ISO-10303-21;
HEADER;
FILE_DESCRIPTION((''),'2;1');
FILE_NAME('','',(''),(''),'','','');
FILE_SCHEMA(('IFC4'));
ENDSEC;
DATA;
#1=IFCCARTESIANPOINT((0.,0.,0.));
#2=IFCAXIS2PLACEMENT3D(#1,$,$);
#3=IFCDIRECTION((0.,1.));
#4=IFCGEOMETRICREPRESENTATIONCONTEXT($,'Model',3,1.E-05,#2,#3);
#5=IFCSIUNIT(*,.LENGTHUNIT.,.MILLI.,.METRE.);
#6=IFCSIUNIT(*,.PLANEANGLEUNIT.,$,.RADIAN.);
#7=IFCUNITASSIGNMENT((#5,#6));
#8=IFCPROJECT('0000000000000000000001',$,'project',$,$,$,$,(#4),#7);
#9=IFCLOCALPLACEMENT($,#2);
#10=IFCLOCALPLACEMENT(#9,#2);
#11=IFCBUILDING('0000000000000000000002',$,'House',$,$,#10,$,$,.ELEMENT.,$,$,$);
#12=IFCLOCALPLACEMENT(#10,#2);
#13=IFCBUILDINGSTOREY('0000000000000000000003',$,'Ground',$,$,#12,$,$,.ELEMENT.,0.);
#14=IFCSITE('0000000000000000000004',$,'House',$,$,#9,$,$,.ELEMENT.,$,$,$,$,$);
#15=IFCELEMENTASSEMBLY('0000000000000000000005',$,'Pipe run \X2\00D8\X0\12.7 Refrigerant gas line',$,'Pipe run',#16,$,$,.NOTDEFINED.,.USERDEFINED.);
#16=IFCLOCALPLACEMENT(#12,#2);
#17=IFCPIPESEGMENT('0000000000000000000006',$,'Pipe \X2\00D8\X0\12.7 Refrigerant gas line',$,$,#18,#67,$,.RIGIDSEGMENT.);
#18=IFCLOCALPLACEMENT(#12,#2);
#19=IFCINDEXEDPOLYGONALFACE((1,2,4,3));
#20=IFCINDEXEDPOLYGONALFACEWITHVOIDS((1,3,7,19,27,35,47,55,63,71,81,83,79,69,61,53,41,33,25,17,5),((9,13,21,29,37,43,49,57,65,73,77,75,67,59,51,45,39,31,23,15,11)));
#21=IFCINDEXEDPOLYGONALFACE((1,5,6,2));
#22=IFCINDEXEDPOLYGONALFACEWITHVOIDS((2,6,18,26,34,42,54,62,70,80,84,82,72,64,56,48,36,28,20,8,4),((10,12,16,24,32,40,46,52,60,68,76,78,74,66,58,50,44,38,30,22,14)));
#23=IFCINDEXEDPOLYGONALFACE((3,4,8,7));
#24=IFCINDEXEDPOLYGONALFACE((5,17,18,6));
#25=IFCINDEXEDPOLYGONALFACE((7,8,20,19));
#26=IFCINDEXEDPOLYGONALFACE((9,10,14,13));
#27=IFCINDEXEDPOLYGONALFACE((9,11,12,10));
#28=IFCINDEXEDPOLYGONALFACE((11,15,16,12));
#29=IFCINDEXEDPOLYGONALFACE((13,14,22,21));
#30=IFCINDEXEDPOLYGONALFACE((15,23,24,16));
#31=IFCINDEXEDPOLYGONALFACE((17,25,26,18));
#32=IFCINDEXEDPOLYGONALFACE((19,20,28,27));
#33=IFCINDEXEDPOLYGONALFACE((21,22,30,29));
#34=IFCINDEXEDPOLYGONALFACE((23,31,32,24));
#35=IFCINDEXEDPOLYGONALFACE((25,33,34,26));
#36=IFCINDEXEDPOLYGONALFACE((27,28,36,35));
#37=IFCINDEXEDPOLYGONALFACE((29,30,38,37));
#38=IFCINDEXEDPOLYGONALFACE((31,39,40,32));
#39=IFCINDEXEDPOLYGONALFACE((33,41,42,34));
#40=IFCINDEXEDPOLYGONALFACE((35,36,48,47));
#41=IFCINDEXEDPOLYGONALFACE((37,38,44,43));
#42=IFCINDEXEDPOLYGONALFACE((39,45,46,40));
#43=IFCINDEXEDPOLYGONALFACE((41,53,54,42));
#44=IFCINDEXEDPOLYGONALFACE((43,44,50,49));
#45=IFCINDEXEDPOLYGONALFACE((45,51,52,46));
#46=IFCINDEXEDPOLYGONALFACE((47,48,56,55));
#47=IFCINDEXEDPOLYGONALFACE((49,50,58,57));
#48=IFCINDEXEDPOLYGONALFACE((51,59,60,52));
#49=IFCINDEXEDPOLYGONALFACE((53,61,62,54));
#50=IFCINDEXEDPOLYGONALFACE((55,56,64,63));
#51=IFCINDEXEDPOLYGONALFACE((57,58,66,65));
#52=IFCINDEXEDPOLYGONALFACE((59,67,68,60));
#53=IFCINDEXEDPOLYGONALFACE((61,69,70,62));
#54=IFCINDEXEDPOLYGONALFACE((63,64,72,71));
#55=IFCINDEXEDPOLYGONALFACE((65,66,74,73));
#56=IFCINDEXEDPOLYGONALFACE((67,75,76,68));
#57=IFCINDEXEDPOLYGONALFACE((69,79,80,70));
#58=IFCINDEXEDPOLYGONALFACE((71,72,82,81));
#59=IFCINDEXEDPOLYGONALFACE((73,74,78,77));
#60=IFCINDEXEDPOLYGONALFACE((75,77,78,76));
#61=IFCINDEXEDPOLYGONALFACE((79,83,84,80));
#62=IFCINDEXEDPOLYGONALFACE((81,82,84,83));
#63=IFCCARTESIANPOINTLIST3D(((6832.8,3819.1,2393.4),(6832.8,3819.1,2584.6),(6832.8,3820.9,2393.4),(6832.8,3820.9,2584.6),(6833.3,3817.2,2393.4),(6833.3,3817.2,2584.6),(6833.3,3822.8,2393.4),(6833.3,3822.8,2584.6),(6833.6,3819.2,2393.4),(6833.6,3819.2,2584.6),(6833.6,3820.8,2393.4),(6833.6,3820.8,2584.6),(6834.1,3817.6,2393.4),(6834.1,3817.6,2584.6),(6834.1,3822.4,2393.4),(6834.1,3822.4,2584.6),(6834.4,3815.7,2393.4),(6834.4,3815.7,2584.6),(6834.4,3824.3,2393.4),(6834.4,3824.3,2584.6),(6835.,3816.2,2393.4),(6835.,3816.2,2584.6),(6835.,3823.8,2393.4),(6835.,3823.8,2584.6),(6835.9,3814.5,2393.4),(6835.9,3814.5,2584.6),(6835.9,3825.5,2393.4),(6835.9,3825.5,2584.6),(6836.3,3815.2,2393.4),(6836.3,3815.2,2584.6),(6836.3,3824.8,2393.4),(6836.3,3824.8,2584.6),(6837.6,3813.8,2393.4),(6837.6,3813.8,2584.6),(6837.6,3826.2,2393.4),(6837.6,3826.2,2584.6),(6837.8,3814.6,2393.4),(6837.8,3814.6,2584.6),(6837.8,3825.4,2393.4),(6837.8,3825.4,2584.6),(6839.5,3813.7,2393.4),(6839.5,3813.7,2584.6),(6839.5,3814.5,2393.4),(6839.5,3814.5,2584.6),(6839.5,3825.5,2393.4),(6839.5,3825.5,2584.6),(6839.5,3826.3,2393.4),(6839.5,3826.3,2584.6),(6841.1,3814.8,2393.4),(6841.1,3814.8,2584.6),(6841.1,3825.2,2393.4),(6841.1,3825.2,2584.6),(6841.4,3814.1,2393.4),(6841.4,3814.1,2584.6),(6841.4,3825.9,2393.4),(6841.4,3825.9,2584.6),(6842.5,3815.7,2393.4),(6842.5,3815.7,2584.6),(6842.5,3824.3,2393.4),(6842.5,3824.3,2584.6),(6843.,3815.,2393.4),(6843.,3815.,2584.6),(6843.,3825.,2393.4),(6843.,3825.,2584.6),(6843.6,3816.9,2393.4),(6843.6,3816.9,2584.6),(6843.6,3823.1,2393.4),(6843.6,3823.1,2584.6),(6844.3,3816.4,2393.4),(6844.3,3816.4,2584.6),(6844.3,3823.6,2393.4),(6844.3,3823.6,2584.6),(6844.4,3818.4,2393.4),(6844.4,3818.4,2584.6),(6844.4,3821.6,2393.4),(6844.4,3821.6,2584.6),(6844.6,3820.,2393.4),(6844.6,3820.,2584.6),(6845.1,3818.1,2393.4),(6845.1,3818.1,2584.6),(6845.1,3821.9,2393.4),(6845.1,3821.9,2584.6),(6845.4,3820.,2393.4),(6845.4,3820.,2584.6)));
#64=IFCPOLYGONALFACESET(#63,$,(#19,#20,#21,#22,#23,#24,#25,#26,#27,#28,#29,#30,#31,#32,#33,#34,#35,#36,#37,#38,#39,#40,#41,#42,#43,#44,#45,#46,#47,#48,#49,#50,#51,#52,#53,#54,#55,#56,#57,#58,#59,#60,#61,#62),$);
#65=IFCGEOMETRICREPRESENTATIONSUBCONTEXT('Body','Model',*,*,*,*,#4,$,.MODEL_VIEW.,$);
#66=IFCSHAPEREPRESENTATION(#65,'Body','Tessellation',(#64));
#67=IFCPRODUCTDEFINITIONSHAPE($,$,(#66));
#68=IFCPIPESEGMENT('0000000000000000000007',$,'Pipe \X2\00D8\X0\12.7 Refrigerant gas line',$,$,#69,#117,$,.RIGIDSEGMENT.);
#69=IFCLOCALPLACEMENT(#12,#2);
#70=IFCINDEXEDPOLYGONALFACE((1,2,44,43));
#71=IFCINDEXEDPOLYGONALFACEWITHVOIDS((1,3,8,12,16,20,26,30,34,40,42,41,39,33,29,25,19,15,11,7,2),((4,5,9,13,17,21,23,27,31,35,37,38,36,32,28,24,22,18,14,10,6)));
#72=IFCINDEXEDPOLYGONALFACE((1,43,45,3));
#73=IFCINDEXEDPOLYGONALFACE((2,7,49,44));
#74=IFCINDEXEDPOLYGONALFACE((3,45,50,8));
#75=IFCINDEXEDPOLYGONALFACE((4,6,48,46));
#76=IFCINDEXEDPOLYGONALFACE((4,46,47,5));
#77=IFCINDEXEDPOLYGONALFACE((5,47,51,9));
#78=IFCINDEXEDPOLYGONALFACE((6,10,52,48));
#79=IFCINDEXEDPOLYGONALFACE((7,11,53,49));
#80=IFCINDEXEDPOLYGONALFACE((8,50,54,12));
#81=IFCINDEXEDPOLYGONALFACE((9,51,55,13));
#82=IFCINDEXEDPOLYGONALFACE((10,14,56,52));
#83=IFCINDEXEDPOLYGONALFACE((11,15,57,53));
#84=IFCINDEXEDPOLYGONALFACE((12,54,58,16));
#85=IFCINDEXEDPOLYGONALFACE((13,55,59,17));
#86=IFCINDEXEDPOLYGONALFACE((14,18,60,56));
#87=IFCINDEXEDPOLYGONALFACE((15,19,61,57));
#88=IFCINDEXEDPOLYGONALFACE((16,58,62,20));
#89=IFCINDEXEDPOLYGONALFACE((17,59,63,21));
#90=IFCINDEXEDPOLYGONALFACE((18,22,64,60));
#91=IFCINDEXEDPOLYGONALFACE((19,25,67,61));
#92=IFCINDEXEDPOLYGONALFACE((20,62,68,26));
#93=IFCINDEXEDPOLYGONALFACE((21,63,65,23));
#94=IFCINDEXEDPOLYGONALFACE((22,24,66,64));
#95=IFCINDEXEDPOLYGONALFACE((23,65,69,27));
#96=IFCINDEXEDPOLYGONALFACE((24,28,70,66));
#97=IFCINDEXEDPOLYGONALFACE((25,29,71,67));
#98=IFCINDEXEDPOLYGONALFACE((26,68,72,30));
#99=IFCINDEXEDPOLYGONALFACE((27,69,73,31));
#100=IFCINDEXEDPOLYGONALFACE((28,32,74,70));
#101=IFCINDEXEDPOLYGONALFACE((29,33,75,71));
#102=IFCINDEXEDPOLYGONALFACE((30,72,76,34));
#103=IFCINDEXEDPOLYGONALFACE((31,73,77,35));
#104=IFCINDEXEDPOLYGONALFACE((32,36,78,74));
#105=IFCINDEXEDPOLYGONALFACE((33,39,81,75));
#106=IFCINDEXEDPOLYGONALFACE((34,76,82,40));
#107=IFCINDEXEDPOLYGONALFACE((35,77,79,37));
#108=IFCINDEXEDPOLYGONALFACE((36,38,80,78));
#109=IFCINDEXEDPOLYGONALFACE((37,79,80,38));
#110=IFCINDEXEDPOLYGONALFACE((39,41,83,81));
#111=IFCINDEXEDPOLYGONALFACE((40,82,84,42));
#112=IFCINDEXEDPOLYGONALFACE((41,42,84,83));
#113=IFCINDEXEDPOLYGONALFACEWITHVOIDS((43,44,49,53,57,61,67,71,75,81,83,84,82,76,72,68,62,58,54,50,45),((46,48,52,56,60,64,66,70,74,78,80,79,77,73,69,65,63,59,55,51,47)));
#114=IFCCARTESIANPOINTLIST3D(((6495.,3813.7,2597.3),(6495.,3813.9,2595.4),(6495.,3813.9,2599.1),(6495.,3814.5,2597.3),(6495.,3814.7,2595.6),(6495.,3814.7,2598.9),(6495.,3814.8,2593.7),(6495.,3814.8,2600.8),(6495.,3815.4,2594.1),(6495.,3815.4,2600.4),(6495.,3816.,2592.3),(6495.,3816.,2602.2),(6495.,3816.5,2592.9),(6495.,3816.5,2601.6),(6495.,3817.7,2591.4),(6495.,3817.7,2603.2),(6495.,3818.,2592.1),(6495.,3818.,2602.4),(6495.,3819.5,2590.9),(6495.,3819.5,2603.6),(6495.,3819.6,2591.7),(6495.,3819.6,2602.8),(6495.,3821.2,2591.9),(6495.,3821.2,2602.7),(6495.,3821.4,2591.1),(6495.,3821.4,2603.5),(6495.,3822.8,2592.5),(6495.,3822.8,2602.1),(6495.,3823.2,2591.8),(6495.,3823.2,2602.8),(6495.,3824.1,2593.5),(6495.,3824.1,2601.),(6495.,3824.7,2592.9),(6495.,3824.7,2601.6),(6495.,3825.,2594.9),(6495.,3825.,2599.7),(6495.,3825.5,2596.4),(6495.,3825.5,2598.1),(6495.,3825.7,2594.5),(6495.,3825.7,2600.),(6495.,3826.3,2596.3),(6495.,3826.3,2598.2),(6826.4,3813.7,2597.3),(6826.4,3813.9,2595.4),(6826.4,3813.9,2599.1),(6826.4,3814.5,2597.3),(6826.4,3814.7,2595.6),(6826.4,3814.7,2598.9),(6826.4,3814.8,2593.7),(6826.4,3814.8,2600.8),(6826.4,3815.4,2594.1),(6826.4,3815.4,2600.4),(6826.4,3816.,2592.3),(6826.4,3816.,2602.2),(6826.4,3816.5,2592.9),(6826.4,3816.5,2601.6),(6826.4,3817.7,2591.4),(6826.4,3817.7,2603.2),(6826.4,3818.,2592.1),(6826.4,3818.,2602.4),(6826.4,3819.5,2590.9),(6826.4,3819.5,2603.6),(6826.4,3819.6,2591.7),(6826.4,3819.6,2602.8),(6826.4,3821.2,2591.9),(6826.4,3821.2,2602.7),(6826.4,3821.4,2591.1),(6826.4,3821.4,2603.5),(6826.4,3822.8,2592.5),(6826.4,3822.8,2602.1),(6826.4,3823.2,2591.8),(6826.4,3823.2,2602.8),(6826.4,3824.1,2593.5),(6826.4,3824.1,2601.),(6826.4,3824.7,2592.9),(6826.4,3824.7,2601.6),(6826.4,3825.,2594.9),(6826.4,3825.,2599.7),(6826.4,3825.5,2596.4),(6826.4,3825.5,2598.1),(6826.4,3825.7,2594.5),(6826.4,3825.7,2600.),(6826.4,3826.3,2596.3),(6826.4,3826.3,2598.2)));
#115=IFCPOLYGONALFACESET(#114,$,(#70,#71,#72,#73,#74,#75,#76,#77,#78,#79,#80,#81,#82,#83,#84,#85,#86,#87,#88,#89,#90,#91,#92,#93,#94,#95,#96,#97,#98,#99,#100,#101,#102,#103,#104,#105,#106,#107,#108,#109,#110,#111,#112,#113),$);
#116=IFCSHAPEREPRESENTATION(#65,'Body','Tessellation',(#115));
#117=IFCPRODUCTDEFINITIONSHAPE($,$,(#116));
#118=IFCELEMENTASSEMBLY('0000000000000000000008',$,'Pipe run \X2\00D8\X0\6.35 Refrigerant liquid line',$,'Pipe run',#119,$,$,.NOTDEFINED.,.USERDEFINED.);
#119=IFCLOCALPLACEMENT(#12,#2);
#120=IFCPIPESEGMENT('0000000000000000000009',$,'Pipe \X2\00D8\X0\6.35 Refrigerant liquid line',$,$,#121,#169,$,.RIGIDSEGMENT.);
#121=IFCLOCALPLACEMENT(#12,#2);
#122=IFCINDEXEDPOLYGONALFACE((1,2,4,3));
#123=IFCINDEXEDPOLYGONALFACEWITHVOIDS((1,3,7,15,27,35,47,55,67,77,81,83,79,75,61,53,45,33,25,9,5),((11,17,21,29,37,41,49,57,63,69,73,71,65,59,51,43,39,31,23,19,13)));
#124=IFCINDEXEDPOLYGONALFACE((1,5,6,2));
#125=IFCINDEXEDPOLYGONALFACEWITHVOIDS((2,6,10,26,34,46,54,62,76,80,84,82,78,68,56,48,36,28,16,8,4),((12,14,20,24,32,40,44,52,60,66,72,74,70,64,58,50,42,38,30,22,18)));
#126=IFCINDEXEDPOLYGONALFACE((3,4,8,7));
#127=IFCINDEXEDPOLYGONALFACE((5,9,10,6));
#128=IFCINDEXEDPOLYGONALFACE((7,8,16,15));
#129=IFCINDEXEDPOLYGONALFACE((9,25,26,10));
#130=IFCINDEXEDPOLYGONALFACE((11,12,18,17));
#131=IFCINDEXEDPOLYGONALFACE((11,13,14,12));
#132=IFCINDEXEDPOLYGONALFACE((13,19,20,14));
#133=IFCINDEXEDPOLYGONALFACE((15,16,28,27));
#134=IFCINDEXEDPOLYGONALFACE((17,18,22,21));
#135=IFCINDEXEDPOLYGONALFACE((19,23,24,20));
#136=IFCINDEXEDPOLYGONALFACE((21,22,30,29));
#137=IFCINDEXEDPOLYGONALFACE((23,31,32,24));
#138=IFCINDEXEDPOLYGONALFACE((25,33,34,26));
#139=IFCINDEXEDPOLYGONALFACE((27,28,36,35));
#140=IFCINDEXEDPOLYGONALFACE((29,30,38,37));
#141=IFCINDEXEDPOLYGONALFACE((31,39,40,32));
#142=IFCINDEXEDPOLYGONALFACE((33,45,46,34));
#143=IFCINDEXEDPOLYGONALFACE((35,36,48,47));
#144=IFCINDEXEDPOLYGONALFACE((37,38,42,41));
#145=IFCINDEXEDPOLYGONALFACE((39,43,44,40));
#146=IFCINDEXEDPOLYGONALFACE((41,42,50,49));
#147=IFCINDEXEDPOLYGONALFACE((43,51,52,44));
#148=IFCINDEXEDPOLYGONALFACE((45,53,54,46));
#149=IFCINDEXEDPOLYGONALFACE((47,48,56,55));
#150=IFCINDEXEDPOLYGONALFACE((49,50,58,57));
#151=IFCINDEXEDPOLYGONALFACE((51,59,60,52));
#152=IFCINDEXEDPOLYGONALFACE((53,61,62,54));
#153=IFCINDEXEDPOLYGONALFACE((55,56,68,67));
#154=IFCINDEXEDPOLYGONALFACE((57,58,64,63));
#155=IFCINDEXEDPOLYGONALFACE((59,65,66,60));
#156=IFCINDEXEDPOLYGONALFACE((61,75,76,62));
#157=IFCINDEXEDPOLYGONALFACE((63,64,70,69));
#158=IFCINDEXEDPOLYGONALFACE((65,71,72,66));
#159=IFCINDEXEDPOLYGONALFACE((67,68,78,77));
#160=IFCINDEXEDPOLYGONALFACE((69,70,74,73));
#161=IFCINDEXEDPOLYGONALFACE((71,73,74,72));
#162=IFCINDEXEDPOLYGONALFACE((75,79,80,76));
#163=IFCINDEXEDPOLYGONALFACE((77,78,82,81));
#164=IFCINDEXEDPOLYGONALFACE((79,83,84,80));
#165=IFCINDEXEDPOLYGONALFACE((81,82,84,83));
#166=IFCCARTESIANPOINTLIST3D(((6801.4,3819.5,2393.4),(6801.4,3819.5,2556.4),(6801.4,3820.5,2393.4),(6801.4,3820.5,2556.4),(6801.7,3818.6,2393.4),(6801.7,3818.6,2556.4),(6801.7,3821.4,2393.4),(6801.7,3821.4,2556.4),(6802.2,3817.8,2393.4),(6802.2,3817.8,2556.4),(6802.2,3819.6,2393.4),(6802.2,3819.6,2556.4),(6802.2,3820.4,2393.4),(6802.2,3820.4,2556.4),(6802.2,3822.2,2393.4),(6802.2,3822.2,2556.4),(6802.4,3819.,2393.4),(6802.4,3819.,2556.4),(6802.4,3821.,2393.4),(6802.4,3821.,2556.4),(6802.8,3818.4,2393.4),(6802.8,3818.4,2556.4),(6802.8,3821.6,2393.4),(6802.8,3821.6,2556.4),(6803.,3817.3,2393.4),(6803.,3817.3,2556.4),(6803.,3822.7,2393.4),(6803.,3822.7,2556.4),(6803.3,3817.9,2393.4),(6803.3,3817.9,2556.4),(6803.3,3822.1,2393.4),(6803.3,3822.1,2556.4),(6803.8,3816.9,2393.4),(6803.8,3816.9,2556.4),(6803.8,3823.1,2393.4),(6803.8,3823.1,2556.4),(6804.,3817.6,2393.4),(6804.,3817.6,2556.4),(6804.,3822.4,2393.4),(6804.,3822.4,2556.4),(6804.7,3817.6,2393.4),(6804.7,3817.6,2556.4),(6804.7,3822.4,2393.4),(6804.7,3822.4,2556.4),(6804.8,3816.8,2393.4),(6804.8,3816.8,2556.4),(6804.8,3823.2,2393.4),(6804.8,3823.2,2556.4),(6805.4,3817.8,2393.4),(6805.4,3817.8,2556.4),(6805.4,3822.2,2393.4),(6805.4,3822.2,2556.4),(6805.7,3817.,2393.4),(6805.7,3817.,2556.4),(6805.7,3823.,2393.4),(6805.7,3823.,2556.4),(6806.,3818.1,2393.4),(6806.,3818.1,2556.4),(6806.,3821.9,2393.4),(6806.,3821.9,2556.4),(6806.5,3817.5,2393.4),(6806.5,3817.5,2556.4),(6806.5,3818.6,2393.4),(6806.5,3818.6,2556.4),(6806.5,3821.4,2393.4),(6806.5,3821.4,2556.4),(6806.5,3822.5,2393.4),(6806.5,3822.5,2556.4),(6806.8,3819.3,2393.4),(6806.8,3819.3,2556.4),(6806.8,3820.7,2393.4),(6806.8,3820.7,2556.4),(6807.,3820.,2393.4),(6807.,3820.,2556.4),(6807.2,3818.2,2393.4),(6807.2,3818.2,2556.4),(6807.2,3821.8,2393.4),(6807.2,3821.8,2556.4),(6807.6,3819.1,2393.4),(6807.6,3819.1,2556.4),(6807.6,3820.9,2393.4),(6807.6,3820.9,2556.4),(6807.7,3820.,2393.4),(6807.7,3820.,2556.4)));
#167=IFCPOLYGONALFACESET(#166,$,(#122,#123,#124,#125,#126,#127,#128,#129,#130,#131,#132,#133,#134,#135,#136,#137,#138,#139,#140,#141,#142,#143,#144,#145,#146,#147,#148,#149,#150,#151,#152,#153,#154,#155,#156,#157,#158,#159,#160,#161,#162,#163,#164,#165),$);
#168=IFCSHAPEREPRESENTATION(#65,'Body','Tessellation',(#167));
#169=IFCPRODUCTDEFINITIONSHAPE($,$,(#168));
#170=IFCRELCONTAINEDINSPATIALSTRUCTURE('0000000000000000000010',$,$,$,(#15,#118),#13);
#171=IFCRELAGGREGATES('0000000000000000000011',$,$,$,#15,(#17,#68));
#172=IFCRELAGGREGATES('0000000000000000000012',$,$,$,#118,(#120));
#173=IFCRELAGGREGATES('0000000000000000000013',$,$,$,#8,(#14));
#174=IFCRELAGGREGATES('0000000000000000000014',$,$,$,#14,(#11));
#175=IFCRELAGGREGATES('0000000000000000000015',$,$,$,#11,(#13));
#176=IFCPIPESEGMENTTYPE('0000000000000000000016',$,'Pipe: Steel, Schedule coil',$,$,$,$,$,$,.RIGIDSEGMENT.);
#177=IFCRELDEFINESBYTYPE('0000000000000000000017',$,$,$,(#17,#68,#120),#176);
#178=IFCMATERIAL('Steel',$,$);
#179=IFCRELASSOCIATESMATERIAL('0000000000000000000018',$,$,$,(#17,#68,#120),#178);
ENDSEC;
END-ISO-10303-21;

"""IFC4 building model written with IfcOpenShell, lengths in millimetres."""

from ifc_helpers import new_model, si_unit, direction, frame, origin, origin_with_axes, origin_2d, place, context, subcontext, project, spatial, hollow_circle, extrude, material, type_object, element, aggregate, save


model = new_model("IFC4")

# Units and contexts
model_context = context("Model", 3, precision=1e-05, world=origin(), true_north=direction((0.0, 1.0)))
body_context = subcontext(model_context, "Body", "Model", "MODEL_VIEW")
ifc_project = project(units=[si_unit("LENGTHUNIT", "METRE", prefix="MILLI"), si_unit("PLANEANGLEUNIT", "RADIAN")], contexts=[model_context])

# Site, building, storey
site_placement = place(None, origin())
site = spatial("IfcSite", under=ifc_project, at=site_placement, Name="House", CompositionType="ELEMENT")
building_placement = place(site_placement, origin())
building = spatial("IfcBuilding", under=site, at=building_placement, Name="House", CompositionType="ELEMENT")
storey_placement = place(building_placement, origin())
storey = spatial("IfcBuildingStorey", under=building, at=storey_placement, Name="Ground", CompositionType="ELEMENT", Elevation=0.0)

# Element assemblies, pipe segments
assembly_1_placement = place(storey_placement, origin_with_axes())
assembly_1 = element("IfcElementAssembly", 1, at=assembly_1_placement, inside=storey, Name="Pipe run Ø12.7 Refrigerant gas line", ObjectType="Pipe run", AssemblyPlace="NOTDEFINED", PredefinedType="USERDEFINED")
ifc_material = material(Name="Steel")
pipe_segment_type = type_object("IfcPipeSegmentType", Name="Pipe: Steel, Schedule coil", PredefinedType="RIGIDSEGMENT")
pipe_segment_1_placement = place(storey_placement, origin_with_axes())
pipe_segment_1 = element("IfcPipeSegment", 2, at=pipe_segment_1_placement, type_object=pipe_segment_type, material=ifc_material, Name="Pipe Ø12.7 Refrigerant gas line", PredefinedType="RIGIDSEGMENT", context=body_context, shape_type="SweptSolid", body=[
    extrude(hollow_circle(Radius=6.3, WallThickness=0.8, at=origin_2d()), frame((6839.1, 3820.0, 2393.4), z_axis=(0.0, 0.0, 1.0), x_axis=(1.0, 0.0, 0.0)), (0.0, 0.0, 1.0), 191.1),
])
pipe_segment_2_placement = place(storey_placement, origin_with_axes())
pipe_segment_2 = element("IfcPipeSegment", 3, at=pipe_segment_2_placement, type_object=pipe_segment_type, material=ifc_material, Name="Pipe Ø12.7 Refrigerant gas line", PredefinedType="RIGIDSEGMENT", context=body_context, shape_type="SweptSolid", body=[
    extrude(hollow_circle(Radius=6.3, WallThickness=0.8, at=origin_2d()), frame((6826.4, 3820.0, 2597.3), z_axis=(-1.0, 0.0, 0.0), x_axis=(0.0, -1.0, 0.0)), (0.0, 0.0, 1.0), 331.4),
])
assembly_2_placement = place(storey_placement, origin_with_axes())
assembly_2 = element("IfcElementAssembly", 4, at=assembly_2_placement, inside=storey, Name="Pipe run Ø6.35 Refrigerant liquid line", ObjectType="Pipe run", AssemblyPlace="NOTDEFINED", PredefinedType="USERDEFINED")
pipe_segment_3_placement = place(storey_placement, origin_with_axes())
pipe_segment_3 = element("IfcPipeSegment", 5, at=pipe_segment_3_placement, type_object=pipe_segment_type, material=ifc_material, Name="Pipe Ø6.35 Refrigerant liquid line", PredefinedType="RIGIDSEGMENT", context=body_context, shape_type="SweptSolid", body=[
    extrude(hollow_circle(Radius=3.2, WallThickness=0.8, at=origin_2d()), frame((6804.5, 3820.0, 2393.4), z_axis=(0.0, 0.0, 1.0), x_axis=(1.0, 0.0, 0.0)), (0.0, 0.0, 1.0), 163.0),
])

aggregate(assembly_1, [pipe_segment_1, pipe_segment_2])
aggregate(assembly_2, [pipe_segment_3])

save(model, "model.ifc")
